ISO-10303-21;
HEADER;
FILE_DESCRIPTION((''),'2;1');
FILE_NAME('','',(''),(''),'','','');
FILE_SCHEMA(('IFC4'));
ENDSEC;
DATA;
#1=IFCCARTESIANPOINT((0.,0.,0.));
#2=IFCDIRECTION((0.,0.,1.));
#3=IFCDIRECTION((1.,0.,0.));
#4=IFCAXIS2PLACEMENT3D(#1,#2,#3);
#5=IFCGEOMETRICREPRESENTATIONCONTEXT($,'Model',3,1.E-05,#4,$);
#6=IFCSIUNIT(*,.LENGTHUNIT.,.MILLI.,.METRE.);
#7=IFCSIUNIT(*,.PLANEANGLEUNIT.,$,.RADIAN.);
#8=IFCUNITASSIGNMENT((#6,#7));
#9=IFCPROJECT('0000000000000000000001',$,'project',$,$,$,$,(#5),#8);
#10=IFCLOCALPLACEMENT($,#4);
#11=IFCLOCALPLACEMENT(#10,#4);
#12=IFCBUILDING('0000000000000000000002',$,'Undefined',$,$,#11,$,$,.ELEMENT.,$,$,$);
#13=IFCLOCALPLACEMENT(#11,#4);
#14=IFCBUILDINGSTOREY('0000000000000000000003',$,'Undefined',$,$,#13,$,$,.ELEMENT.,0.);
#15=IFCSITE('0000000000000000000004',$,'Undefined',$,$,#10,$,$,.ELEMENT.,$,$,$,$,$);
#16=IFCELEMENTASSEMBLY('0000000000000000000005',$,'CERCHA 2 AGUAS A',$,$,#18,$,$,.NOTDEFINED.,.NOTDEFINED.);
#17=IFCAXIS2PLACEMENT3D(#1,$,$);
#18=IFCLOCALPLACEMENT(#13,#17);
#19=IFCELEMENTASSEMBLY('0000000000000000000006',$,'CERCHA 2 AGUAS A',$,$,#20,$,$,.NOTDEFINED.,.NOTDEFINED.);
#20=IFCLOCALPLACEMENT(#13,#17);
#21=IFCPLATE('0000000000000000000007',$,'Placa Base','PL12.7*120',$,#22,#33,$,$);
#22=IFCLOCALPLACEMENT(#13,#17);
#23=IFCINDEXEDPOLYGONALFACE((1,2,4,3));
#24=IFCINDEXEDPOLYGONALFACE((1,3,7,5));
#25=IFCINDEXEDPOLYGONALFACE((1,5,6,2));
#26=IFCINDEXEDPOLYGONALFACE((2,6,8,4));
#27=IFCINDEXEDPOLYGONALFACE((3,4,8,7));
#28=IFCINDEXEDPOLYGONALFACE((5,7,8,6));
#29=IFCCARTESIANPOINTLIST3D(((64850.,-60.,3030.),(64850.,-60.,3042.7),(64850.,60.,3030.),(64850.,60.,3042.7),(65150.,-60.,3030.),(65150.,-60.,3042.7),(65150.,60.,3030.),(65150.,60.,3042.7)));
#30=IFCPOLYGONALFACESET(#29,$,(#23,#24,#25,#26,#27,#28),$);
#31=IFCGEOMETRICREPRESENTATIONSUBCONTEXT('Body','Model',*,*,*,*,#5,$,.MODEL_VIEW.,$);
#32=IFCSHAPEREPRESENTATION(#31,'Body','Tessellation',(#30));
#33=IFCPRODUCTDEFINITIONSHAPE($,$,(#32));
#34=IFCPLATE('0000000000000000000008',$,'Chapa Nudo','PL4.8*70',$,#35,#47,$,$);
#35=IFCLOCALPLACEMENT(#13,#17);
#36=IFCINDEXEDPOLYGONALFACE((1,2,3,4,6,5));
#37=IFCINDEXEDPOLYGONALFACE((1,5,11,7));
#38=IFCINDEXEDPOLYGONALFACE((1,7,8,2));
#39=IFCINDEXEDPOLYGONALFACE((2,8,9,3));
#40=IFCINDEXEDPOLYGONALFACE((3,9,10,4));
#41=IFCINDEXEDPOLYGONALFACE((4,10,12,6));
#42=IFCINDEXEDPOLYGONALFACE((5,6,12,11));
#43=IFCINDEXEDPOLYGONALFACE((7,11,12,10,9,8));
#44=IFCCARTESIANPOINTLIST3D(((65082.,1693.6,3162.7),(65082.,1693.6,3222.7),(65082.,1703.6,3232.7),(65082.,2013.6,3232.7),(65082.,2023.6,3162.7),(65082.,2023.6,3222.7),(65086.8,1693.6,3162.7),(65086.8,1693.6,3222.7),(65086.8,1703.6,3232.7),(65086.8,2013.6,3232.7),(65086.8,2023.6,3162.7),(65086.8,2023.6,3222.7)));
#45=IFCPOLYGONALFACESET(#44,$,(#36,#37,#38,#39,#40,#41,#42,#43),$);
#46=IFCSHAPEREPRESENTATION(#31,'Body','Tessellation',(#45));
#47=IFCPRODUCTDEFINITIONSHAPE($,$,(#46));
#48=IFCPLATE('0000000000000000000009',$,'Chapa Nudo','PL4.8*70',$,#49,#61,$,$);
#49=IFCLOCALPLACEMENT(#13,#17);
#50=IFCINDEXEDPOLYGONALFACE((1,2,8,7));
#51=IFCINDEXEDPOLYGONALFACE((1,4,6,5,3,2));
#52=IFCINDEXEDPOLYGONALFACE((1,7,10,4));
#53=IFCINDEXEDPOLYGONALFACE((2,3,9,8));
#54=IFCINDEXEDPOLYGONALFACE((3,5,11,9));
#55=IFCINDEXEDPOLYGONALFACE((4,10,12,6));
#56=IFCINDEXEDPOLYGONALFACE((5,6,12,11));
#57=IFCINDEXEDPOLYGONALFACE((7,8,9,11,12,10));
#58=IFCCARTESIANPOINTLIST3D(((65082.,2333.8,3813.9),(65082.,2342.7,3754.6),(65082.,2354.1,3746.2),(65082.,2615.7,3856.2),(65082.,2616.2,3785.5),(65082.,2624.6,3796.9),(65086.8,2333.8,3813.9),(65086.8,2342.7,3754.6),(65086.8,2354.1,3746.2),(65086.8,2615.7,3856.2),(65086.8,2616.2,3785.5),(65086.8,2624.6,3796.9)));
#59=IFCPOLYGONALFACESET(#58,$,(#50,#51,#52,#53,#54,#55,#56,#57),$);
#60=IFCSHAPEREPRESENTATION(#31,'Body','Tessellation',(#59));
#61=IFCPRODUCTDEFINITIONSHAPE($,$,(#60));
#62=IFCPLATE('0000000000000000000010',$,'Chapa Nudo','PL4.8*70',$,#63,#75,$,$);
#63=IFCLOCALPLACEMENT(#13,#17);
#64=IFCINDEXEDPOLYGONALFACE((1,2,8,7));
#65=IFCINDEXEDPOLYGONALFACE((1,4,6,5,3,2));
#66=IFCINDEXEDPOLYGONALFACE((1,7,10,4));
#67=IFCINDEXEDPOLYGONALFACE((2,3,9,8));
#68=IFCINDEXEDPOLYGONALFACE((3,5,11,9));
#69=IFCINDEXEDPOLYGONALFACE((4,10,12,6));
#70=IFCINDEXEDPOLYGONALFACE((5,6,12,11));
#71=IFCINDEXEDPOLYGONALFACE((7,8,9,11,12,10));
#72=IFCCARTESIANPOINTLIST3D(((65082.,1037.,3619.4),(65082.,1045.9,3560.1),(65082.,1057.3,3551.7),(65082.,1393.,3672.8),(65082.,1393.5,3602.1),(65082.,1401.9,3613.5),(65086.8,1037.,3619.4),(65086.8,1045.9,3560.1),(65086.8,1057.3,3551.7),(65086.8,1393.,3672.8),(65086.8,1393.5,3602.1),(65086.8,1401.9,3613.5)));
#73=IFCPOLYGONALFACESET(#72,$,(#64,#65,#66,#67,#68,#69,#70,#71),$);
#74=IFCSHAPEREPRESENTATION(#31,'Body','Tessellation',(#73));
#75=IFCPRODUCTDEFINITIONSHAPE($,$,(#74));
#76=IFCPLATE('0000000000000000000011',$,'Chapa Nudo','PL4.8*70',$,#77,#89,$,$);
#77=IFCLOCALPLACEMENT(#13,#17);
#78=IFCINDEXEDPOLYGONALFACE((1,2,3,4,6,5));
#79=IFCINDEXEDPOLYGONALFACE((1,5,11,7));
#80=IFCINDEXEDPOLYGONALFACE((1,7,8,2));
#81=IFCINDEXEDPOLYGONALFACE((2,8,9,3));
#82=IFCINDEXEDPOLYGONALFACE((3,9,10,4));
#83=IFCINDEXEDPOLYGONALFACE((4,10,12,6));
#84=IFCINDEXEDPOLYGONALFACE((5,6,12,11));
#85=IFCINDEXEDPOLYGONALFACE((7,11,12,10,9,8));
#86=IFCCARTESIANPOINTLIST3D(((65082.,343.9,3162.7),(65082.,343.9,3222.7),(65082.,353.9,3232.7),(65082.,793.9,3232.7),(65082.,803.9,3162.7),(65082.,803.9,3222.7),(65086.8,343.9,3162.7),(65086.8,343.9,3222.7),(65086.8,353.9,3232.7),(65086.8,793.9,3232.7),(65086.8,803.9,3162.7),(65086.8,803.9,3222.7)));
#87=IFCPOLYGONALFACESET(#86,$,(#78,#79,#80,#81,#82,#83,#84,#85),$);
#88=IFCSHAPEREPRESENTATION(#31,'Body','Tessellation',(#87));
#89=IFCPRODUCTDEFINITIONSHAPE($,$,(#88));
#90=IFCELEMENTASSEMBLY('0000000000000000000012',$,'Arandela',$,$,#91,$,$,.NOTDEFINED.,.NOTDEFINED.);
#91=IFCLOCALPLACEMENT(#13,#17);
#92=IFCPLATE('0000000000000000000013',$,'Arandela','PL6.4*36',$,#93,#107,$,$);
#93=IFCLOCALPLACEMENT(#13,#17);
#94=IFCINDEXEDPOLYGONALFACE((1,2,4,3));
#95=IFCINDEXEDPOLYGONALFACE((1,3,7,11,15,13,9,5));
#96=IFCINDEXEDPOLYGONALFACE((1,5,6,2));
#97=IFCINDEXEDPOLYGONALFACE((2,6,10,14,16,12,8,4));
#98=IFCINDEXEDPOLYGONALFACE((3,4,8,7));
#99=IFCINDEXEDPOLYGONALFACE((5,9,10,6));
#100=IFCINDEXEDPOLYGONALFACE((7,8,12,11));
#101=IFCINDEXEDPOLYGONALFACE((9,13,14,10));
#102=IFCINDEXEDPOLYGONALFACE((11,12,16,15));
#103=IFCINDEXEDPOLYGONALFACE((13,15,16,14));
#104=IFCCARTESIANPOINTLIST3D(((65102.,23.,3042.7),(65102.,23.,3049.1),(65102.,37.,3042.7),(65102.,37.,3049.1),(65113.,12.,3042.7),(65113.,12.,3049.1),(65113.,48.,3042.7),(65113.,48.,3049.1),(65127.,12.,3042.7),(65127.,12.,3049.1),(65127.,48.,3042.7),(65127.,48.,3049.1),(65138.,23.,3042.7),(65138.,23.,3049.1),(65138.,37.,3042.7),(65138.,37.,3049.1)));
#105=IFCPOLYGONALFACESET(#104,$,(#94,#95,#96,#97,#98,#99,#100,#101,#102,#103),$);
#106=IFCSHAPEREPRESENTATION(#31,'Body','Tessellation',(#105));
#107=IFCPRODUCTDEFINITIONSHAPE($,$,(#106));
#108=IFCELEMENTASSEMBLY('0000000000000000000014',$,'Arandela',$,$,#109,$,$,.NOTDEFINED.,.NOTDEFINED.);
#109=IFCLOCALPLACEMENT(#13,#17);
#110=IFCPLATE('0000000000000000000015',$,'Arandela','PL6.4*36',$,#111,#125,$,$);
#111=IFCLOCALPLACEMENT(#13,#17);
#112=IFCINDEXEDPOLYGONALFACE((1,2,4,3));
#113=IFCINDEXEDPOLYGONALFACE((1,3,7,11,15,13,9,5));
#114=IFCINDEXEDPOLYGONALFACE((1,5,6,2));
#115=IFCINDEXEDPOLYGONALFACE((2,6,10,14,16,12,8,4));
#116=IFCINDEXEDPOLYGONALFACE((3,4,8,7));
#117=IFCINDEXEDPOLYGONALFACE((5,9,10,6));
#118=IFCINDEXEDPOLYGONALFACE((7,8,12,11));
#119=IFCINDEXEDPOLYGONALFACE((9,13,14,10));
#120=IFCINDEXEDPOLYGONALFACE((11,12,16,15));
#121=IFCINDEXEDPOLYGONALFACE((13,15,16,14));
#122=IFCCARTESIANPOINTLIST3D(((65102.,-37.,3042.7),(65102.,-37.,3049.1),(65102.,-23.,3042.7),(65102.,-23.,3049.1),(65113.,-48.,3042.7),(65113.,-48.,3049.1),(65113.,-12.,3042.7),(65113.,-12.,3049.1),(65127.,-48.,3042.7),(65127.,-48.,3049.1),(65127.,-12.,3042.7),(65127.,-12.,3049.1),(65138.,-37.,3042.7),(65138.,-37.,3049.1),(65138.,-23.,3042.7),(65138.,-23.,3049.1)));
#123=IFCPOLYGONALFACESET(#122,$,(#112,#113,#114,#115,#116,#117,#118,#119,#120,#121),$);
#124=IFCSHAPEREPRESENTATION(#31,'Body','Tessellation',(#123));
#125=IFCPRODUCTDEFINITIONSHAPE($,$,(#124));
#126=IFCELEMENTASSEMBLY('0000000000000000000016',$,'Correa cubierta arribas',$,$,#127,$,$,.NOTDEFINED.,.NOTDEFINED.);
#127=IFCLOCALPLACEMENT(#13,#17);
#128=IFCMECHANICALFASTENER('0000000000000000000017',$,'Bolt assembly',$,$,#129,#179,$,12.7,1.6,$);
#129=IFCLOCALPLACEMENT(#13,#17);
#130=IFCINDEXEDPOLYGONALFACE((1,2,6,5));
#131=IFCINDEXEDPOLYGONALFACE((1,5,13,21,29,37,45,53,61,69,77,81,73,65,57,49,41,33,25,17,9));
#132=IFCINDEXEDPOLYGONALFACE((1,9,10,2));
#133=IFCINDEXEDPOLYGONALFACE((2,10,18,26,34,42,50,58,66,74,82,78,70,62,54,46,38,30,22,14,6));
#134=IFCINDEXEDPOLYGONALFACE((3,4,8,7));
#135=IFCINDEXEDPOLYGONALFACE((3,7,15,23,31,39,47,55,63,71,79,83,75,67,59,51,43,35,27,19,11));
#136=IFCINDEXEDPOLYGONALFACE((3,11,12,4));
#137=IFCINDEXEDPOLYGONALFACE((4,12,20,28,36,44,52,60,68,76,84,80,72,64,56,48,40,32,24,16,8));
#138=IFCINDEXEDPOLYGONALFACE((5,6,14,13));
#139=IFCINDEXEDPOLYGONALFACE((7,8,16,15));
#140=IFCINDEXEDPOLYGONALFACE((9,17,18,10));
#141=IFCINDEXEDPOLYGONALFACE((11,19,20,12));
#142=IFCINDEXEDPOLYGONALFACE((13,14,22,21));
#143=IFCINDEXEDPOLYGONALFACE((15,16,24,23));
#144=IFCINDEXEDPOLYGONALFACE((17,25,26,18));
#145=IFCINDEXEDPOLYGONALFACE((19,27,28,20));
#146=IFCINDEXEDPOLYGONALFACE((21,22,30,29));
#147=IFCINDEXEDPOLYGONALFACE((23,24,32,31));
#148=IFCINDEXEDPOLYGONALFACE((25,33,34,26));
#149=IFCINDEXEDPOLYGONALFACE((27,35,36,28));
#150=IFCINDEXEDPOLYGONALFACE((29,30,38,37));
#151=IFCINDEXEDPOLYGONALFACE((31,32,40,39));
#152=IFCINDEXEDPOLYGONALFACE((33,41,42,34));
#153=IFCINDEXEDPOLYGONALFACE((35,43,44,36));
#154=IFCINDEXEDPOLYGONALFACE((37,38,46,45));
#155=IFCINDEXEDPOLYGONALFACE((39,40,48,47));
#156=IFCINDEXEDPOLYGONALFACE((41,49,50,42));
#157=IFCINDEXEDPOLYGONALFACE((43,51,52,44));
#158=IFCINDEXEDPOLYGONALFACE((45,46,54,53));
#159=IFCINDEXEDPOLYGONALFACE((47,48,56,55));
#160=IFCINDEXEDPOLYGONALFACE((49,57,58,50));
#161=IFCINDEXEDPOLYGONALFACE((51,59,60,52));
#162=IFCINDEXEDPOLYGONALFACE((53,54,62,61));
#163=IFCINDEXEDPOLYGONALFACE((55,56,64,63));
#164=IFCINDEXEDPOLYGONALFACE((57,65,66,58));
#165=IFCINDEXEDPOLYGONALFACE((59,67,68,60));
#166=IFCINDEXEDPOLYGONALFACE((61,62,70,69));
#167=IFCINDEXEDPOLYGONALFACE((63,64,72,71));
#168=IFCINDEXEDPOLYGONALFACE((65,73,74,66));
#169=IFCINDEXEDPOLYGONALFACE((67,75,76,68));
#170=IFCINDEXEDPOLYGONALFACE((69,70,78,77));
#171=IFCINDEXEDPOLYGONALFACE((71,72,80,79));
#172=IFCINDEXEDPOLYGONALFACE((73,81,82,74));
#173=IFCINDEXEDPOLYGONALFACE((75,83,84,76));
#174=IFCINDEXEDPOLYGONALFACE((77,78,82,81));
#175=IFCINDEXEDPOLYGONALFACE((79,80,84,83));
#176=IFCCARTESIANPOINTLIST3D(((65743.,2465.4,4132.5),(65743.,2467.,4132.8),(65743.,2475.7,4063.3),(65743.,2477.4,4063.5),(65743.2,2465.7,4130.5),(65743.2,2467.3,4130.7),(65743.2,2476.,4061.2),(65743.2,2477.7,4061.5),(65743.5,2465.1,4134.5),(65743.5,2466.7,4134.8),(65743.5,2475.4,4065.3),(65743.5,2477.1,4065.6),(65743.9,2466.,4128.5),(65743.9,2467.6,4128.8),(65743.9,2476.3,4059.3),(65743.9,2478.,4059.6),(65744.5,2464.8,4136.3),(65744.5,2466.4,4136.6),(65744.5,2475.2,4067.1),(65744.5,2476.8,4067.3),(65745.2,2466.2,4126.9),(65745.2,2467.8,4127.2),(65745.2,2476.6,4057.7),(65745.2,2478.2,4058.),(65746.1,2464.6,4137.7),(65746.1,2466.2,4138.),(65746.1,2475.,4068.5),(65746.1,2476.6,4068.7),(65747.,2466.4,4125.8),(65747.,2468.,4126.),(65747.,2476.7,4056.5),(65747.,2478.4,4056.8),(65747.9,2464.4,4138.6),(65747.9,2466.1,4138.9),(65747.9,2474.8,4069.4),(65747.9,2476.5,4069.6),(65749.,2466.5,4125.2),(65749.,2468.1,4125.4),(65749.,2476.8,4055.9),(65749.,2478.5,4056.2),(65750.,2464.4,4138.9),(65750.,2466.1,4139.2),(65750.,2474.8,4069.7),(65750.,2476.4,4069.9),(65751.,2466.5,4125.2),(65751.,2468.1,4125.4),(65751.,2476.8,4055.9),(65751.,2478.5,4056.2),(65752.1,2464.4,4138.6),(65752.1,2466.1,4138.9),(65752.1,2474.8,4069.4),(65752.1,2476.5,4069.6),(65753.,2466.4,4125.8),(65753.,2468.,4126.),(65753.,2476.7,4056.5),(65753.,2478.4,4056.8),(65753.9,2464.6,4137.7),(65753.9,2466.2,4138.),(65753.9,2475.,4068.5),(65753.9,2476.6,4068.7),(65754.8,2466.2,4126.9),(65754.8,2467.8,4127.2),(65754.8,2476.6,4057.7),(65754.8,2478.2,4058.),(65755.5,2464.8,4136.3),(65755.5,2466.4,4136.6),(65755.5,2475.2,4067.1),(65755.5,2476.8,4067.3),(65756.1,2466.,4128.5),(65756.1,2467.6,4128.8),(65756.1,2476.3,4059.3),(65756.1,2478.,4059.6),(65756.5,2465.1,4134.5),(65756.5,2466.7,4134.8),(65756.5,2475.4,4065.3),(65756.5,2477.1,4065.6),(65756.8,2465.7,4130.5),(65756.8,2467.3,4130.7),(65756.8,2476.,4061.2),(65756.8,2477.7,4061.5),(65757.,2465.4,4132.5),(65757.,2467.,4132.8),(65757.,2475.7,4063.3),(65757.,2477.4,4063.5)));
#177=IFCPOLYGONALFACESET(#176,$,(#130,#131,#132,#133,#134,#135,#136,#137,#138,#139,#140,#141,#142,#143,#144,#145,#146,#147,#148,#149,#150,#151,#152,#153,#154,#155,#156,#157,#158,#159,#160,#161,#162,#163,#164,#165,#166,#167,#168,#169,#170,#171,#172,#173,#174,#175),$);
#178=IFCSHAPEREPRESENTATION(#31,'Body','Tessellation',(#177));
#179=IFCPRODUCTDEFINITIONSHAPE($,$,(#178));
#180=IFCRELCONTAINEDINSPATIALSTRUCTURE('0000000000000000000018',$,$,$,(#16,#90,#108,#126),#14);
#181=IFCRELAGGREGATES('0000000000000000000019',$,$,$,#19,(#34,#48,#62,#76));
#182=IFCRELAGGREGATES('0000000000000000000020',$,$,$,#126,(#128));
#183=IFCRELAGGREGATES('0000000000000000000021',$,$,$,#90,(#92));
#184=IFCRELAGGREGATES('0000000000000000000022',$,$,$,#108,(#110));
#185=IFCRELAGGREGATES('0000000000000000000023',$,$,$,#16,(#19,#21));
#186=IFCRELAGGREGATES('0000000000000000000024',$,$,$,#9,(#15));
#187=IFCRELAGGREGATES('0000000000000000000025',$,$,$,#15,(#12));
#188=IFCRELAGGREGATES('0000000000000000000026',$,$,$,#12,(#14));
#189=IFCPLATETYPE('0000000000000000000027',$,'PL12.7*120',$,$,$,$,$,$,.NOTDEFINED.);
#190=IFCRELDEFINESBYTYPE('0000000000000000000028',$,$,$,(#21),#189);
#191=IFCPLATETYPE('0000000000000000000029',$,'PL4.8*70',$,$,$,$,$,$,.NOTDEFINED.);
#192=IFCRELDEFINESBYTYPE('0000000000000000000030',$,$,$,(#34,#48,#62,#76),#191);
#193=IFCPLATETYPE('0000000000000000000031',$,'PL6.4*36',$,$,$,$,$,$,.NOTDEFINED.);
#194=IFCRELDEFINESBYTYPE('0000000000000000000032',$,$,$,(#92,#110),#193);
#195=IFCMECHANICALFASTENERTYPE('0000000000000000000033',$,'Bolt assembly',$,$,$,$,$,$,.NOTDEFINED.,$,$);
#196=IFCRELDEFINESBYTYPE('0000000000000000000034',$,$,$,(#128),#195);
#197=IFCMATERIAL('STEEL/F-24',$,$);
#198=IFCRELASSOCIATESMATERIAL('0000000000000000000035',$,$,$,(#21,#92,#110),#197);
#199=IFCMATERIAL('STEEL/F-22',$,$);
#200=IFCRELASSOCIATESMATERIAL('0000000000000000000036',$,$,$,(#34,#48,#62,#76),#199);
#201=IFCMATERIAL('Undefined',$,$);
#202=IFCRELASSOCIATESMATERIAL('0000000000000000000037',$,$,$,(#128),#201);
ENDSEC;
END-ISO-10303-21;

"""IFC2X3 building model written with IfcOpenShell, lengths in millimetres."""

from ifc_helpers import new_model, si_unit, frame, origin_with_axes, origin_2d_with_axis, place, context, subcontext, project, spatial, polyline, circle, outline, extrude, source, transform, mapped, material, type_object, element, aggregate, save


model = new_model("IFC2X3")

# Units and contexts
model_context = context("Model", 3, precision=1e-05, world=origin_with_axes())
body_context = subcontext(model_context, "Body", "Model", "MODEL_VIEW")
ifc_project = project(units=[si_unit("LENGTHUNIT", "METRE", prefix="MILLI"), si_unit("PLANEANGLEUNIT", "RADIAN")], contexts=[model_context])

# Site, building, storey
site_placement = place(None, origin_with_axes())
site = spatial("IfcSite", under=ifc_project, at=site_placement, Name="Undefined", CompositionType="ELEMENT")
building_placement = place(site_placement, origin_with_axes())
building = spatial("IfcBuilding", under=site, at=building_placement, Name="Undefined", CompositionType="ELEMENT")
storey_placement = place(building_placement, origin_with_axes())
storey = spatial("IfcBuildingStorey", under=building, at=storey_placement, Name="Undefined", CompositionType="ELEMENT", Elevation=0.0)

# Shared definitions
ifc_material_1 = material(Name="STEEL/F-24")

# Element assemblies
assembly_1_placement = place(storey_placement, origin_with_axes())
assembly_1 = element("IfcElementAssembly", 1, at=assembly_1_placement, inside=storey, Name="CERCHA 2 AGUAS A", AssemblyPlace="NOTDEFINED", PredefinedType="NOTDEFINED")
assembly_2_placement = place(assembly_1_placement, origin_with_axes())
assembly_2 = element("IfcElementAssembly", 2, at=assembly_2_placement, Name="CERCHA 2 AGUAS A", AssemblyPlace="NOTDEFINED", PredefinedType="NOTDEFINED")
ifc_material_2 = material(Name="STEEL/F-22")

# Plates
plate_type_1 = type_object("IfcPlateType", Name="PL12.7*120", PredefinedType="NOTDEFINED")
plate_1_placement = place(assembly_1_placement, frame((65150.0, 60.0, 3036.3), z_axis=(0.0, 0.0, 1.0), x_axis=(-1.0, 0.0, 0.0)))
plate_1 = element("IfcPlate", 3, at=plate_1_placement, type_object=plate_type_1, material=ifc_material_1, Name="Placa Base", Description="PL12.7*120", context=body_context, shape_type="SweptSolid", body=[
    extrude(outline(polyline([(0.0, 0.0), (300.0, 0.0), (300.0, 120.0), (0.0, 120.0), (0.0, 0.0)])), frame((0.0, 0.0, -6.3), z_axis=(0.0, 0.0, 1.0), x_axis=(1.0, 0.0, 0.0)), (0.0, 0.0, 1.0), 12.7),
])
plate_type_2 = type_object("IfcPlateType", Name="PL4.8*70", PredefinedType="NOTDEFINED")
plate_2_placement = place(assembly_2_placement, frame((65084.4, 1693.6, 3232.7), z_axis=(1.0, 0.0, 0.0), x_axis=(0.0, 0.0, -1.0)))
plate_2 = element("IfcPlate", 4, at=plate_2_placement, type_object=plate_type_2, material=ifc_material_2, Name="Chapa Nudo", Description="PL4.8*70", context=body_context, shape_type="SweptSolid", body=[
    extrude(outline(polyline([(0.0, 10.0), (10.0, 0.0), (70.0, 0.0), (70.0, 330.0), (10.0, 330.0), (0.0, 320.0), (0.0, 10.0)])), frame((0.0, 0.0, -2.4), z_axis=(0.0, 0.0, 1.0), x_axis=(1.0, 0.0, 0.0)), (0.0, 0.0, 1.0), 4.8),
])
plate_3_placement = place(assembly_2_placement, frame((65084.4, 2333.8, 3813.9), z_axis=(1.0, 0.0, 0.0), x_axis=(0.0, 0.14834, -0.988936)))
plate_3 = element("IfcPlate", 5, at=plate_3_placement, type_object=plate_type_2, material=ifc_material_2, Name="Chapa Nudo", Description="PL4.8*70", context=body_context, shape_type="SweptSolid", body=[
    extrude(outline(polyline([(0.0, 0.0), (60.0, 0.0), (70.0, 10.0), (70.0, 275.0), (60.0, 285.0), (0.0, 285.0), (0.0, 0.0)])), frame((0.0, 0.0, -2.4), z_axis=(0.0, 0.0, 1.0), x_axis=(1.0, 0.0, 0.0)), (0.0, 0.0, 1.0), 4.8),
])
plate_4_placement = place(assembly_2_placement, frame((65084.4, 1037.0, 3619.4), z_axis=(1.0, 0.0, 0.0), x_axis=(0.0, 0.148337, -0.988937)))
plate_4 = element("IfcPlate", 6, at=plate_4_placement, type_object=plate_type_2, material=ifc_material_2, Name="Chapa Nudo", Description="PL4.8*70", context=body_context, shape_type="SweptSolid", body=[
    extrude(outline(polyline([(0.0, 0.0), (60.0, 0.0), (70.0, 10.0), (70.0, 350.0), (60.0, 360.0), (0.0, 360.0), (0.0, 0.0)])), frame((0.0, 0.0, -2.4), z_axis=(0.0, 0.0, 1.0), x_axis=(1.0, 0.0, 0.0)), (0.0, 0.0, 1.0), 4.8),
])
plate_5_placement = place(assembly_2_placement, frame((65084.4, 343.9, 3232.7), z_axis=(1.0, 0.0, 0.0), x_axis=(0.0, 0.0, -1.0)))
plate_5 = element("IfcPlate", 7, at=plate_5_placement, type_object=plate_type_2, material=ifc_material_2, Name="Chapa Nudo", Description="PL4.8*70", context=body_context, shape_type="SweptSolid", body=[
    extrude(outline(polyline([(0.0, 10.0), (10.0, 0.0), (70.0, 0.0), (70.0, 460.0), (10.0, 460.0), (0.0, 450.0), (0.0, 10.0)])), frame((0.0, 0.0, -2.4), z_axis=(0.0, 0.0, 1.0), x_axis=(1.0, 0.0, 0.0)), (0.0, 0.0, 1.0), 4.8),
])
aggregate(assembly_2, [plate_2, plate_3, plate_4, plate_5])

# Element assemblies, plates
assembly_3_placement = place(storey_placement, origin_with_axes())
assembly_3 = element("IfcElementAssembly", 8, at=assembly_3_placement, inside=storey, Name="Arandela", AssemblyPlace="NOTDEFINED", PredefinedType="NOTDEFINED")
plate_type_3 = type_object("IfcPlateType", Name="PL6.4*36", PredefinedType="NOTDEFINED")
plate_6_placement = place(assembly_3_placement, frame((65102.0, 48.0, 3045.9), z_axis=(0.0, 0.0, 1.0), x_axis=(0.0, -1.0, 0.0)))
plate_6 = element("IfcPlate", 9, at=plate_6_placement, type_object=plate_type_3, material=ifc_material_1, Name="Arandela", Description="PL6.4*36", context=body_context, shape_type="SweptSolid", body=[
    extrude(outline(polyline([(0.0, 11.0), (11.0, 0.0), (25.0, 0.0), (36.0, 11.0), (36.0, 25.0), (25.0, 36.0), (11.0, 36.0), (0.0, 25.0), (0.0, 11.0)])), frame((0.0, 0.0, -3.2), z_axis=(0.0, 0.0, 1.0), x_axis=(1.0, 0.0, 0.0)), (0.0, 0.0, 1.0), 6.4),
])
assembly_4_placement = place(storey_placement, origin_with_axes())
assembly_4 = element("IfcElementAssembly", 10, at=assembly_4_placement, inside=storey, Name="Arandela", AssemblyPlace="NOTDEFINED", PredefinedType="NOTDEFINED")
plate_7_placement = place(assembly_4_placement, frame((65102.0, -12.0, 3045.9), z_axis=(0.0, 0.0, 1.0), x_axis=(0.0, -1.0, 0.0)))
plate_7 = element("IfcPlate", 11, at=plate_7_placement, type_object=plate_type_3, material=ifc_material_1, Name="Arandela", Description="PL6.4*36", context=body_context, shape_type="SweptSolid", body=[
    extrude(outline(polyline([(0.0, 11.0), (11.0, 0.0), (25.0, 0.0), (36.0, 11.0), (36.0, 25.0), (25.0, 36.0), (11.0, 36.0), (0.0, 25.0), (0.0, 11.0)])), frame((0.0, 0.0, -3.2), z_axis=(0.0, 0.0, 1.0), x_axis=(1.0, 0.0, 0.0)), (0.0, 0.0, 1.0), 6.4),
])

# Shared definitions
ifc_material_3 = material(Name="Undefined")
mechanical_fastener_type = type_object("IfcMechanicalFastenerType", Name="Bolt assembly")

# Element assembly, mechanical fastener
assembly_5_placement = place(storey_placement, origin_with_axes())
assembly_5 = element("IfcElementAssembly", 12, at=assembly_5_placement, inside=storey, Name="Correa cubierta arribas", AssemblyPlace="NOTDEFINED", PredefinedType="NOTDEFINED")
shared_shape_1 = source(origin_with_axes(), body_context, "Body", "SweptSolid", [
    extrude(circle(Radius=7.0, at=origin_2d_with_axis()), frame((0.0, 6.4, 0.0), z_axis=(0.0, 1.0, 0.0), x_axis=(1.0, 0.0, 0.0)), (0.0, 0.0, 1.0), 1.7),
])
mechanical_fastener_1_placement = place(assembly_5_placement, frame((65750.0, 2483.8, 4064.0), z_axis=(1.0, 0.0, 0.0), x_axis=(0.0, -0.148209, 0.988956)))
mechanical_fastener_1 = element("IfcMechanicalFastener", 13, at=mechanical_fastener_1_placement, type_object=mechanical_fastener_type, material=ifc_material_3, Name="Bolt assembly", NominalDiameter=12.7, NominalLength=1.6, context=body_context, shape_type="MappedRepresentation", body=[
    mapped(shared_shape_1, transform((0.0, 0.0, 0.0))),
    mapped(shared_shape_1, transform((70.0, 0.0, 0.0))),
])
aggregate(assembly_5, [mechanical_fastener_1])

aggregate(assembly_3, [plate_6])
aggregate(assembly_4, [plate_7])
aggregate(assembly_1, [assembly_2, plate_1])

save(model, "model.ifc")
